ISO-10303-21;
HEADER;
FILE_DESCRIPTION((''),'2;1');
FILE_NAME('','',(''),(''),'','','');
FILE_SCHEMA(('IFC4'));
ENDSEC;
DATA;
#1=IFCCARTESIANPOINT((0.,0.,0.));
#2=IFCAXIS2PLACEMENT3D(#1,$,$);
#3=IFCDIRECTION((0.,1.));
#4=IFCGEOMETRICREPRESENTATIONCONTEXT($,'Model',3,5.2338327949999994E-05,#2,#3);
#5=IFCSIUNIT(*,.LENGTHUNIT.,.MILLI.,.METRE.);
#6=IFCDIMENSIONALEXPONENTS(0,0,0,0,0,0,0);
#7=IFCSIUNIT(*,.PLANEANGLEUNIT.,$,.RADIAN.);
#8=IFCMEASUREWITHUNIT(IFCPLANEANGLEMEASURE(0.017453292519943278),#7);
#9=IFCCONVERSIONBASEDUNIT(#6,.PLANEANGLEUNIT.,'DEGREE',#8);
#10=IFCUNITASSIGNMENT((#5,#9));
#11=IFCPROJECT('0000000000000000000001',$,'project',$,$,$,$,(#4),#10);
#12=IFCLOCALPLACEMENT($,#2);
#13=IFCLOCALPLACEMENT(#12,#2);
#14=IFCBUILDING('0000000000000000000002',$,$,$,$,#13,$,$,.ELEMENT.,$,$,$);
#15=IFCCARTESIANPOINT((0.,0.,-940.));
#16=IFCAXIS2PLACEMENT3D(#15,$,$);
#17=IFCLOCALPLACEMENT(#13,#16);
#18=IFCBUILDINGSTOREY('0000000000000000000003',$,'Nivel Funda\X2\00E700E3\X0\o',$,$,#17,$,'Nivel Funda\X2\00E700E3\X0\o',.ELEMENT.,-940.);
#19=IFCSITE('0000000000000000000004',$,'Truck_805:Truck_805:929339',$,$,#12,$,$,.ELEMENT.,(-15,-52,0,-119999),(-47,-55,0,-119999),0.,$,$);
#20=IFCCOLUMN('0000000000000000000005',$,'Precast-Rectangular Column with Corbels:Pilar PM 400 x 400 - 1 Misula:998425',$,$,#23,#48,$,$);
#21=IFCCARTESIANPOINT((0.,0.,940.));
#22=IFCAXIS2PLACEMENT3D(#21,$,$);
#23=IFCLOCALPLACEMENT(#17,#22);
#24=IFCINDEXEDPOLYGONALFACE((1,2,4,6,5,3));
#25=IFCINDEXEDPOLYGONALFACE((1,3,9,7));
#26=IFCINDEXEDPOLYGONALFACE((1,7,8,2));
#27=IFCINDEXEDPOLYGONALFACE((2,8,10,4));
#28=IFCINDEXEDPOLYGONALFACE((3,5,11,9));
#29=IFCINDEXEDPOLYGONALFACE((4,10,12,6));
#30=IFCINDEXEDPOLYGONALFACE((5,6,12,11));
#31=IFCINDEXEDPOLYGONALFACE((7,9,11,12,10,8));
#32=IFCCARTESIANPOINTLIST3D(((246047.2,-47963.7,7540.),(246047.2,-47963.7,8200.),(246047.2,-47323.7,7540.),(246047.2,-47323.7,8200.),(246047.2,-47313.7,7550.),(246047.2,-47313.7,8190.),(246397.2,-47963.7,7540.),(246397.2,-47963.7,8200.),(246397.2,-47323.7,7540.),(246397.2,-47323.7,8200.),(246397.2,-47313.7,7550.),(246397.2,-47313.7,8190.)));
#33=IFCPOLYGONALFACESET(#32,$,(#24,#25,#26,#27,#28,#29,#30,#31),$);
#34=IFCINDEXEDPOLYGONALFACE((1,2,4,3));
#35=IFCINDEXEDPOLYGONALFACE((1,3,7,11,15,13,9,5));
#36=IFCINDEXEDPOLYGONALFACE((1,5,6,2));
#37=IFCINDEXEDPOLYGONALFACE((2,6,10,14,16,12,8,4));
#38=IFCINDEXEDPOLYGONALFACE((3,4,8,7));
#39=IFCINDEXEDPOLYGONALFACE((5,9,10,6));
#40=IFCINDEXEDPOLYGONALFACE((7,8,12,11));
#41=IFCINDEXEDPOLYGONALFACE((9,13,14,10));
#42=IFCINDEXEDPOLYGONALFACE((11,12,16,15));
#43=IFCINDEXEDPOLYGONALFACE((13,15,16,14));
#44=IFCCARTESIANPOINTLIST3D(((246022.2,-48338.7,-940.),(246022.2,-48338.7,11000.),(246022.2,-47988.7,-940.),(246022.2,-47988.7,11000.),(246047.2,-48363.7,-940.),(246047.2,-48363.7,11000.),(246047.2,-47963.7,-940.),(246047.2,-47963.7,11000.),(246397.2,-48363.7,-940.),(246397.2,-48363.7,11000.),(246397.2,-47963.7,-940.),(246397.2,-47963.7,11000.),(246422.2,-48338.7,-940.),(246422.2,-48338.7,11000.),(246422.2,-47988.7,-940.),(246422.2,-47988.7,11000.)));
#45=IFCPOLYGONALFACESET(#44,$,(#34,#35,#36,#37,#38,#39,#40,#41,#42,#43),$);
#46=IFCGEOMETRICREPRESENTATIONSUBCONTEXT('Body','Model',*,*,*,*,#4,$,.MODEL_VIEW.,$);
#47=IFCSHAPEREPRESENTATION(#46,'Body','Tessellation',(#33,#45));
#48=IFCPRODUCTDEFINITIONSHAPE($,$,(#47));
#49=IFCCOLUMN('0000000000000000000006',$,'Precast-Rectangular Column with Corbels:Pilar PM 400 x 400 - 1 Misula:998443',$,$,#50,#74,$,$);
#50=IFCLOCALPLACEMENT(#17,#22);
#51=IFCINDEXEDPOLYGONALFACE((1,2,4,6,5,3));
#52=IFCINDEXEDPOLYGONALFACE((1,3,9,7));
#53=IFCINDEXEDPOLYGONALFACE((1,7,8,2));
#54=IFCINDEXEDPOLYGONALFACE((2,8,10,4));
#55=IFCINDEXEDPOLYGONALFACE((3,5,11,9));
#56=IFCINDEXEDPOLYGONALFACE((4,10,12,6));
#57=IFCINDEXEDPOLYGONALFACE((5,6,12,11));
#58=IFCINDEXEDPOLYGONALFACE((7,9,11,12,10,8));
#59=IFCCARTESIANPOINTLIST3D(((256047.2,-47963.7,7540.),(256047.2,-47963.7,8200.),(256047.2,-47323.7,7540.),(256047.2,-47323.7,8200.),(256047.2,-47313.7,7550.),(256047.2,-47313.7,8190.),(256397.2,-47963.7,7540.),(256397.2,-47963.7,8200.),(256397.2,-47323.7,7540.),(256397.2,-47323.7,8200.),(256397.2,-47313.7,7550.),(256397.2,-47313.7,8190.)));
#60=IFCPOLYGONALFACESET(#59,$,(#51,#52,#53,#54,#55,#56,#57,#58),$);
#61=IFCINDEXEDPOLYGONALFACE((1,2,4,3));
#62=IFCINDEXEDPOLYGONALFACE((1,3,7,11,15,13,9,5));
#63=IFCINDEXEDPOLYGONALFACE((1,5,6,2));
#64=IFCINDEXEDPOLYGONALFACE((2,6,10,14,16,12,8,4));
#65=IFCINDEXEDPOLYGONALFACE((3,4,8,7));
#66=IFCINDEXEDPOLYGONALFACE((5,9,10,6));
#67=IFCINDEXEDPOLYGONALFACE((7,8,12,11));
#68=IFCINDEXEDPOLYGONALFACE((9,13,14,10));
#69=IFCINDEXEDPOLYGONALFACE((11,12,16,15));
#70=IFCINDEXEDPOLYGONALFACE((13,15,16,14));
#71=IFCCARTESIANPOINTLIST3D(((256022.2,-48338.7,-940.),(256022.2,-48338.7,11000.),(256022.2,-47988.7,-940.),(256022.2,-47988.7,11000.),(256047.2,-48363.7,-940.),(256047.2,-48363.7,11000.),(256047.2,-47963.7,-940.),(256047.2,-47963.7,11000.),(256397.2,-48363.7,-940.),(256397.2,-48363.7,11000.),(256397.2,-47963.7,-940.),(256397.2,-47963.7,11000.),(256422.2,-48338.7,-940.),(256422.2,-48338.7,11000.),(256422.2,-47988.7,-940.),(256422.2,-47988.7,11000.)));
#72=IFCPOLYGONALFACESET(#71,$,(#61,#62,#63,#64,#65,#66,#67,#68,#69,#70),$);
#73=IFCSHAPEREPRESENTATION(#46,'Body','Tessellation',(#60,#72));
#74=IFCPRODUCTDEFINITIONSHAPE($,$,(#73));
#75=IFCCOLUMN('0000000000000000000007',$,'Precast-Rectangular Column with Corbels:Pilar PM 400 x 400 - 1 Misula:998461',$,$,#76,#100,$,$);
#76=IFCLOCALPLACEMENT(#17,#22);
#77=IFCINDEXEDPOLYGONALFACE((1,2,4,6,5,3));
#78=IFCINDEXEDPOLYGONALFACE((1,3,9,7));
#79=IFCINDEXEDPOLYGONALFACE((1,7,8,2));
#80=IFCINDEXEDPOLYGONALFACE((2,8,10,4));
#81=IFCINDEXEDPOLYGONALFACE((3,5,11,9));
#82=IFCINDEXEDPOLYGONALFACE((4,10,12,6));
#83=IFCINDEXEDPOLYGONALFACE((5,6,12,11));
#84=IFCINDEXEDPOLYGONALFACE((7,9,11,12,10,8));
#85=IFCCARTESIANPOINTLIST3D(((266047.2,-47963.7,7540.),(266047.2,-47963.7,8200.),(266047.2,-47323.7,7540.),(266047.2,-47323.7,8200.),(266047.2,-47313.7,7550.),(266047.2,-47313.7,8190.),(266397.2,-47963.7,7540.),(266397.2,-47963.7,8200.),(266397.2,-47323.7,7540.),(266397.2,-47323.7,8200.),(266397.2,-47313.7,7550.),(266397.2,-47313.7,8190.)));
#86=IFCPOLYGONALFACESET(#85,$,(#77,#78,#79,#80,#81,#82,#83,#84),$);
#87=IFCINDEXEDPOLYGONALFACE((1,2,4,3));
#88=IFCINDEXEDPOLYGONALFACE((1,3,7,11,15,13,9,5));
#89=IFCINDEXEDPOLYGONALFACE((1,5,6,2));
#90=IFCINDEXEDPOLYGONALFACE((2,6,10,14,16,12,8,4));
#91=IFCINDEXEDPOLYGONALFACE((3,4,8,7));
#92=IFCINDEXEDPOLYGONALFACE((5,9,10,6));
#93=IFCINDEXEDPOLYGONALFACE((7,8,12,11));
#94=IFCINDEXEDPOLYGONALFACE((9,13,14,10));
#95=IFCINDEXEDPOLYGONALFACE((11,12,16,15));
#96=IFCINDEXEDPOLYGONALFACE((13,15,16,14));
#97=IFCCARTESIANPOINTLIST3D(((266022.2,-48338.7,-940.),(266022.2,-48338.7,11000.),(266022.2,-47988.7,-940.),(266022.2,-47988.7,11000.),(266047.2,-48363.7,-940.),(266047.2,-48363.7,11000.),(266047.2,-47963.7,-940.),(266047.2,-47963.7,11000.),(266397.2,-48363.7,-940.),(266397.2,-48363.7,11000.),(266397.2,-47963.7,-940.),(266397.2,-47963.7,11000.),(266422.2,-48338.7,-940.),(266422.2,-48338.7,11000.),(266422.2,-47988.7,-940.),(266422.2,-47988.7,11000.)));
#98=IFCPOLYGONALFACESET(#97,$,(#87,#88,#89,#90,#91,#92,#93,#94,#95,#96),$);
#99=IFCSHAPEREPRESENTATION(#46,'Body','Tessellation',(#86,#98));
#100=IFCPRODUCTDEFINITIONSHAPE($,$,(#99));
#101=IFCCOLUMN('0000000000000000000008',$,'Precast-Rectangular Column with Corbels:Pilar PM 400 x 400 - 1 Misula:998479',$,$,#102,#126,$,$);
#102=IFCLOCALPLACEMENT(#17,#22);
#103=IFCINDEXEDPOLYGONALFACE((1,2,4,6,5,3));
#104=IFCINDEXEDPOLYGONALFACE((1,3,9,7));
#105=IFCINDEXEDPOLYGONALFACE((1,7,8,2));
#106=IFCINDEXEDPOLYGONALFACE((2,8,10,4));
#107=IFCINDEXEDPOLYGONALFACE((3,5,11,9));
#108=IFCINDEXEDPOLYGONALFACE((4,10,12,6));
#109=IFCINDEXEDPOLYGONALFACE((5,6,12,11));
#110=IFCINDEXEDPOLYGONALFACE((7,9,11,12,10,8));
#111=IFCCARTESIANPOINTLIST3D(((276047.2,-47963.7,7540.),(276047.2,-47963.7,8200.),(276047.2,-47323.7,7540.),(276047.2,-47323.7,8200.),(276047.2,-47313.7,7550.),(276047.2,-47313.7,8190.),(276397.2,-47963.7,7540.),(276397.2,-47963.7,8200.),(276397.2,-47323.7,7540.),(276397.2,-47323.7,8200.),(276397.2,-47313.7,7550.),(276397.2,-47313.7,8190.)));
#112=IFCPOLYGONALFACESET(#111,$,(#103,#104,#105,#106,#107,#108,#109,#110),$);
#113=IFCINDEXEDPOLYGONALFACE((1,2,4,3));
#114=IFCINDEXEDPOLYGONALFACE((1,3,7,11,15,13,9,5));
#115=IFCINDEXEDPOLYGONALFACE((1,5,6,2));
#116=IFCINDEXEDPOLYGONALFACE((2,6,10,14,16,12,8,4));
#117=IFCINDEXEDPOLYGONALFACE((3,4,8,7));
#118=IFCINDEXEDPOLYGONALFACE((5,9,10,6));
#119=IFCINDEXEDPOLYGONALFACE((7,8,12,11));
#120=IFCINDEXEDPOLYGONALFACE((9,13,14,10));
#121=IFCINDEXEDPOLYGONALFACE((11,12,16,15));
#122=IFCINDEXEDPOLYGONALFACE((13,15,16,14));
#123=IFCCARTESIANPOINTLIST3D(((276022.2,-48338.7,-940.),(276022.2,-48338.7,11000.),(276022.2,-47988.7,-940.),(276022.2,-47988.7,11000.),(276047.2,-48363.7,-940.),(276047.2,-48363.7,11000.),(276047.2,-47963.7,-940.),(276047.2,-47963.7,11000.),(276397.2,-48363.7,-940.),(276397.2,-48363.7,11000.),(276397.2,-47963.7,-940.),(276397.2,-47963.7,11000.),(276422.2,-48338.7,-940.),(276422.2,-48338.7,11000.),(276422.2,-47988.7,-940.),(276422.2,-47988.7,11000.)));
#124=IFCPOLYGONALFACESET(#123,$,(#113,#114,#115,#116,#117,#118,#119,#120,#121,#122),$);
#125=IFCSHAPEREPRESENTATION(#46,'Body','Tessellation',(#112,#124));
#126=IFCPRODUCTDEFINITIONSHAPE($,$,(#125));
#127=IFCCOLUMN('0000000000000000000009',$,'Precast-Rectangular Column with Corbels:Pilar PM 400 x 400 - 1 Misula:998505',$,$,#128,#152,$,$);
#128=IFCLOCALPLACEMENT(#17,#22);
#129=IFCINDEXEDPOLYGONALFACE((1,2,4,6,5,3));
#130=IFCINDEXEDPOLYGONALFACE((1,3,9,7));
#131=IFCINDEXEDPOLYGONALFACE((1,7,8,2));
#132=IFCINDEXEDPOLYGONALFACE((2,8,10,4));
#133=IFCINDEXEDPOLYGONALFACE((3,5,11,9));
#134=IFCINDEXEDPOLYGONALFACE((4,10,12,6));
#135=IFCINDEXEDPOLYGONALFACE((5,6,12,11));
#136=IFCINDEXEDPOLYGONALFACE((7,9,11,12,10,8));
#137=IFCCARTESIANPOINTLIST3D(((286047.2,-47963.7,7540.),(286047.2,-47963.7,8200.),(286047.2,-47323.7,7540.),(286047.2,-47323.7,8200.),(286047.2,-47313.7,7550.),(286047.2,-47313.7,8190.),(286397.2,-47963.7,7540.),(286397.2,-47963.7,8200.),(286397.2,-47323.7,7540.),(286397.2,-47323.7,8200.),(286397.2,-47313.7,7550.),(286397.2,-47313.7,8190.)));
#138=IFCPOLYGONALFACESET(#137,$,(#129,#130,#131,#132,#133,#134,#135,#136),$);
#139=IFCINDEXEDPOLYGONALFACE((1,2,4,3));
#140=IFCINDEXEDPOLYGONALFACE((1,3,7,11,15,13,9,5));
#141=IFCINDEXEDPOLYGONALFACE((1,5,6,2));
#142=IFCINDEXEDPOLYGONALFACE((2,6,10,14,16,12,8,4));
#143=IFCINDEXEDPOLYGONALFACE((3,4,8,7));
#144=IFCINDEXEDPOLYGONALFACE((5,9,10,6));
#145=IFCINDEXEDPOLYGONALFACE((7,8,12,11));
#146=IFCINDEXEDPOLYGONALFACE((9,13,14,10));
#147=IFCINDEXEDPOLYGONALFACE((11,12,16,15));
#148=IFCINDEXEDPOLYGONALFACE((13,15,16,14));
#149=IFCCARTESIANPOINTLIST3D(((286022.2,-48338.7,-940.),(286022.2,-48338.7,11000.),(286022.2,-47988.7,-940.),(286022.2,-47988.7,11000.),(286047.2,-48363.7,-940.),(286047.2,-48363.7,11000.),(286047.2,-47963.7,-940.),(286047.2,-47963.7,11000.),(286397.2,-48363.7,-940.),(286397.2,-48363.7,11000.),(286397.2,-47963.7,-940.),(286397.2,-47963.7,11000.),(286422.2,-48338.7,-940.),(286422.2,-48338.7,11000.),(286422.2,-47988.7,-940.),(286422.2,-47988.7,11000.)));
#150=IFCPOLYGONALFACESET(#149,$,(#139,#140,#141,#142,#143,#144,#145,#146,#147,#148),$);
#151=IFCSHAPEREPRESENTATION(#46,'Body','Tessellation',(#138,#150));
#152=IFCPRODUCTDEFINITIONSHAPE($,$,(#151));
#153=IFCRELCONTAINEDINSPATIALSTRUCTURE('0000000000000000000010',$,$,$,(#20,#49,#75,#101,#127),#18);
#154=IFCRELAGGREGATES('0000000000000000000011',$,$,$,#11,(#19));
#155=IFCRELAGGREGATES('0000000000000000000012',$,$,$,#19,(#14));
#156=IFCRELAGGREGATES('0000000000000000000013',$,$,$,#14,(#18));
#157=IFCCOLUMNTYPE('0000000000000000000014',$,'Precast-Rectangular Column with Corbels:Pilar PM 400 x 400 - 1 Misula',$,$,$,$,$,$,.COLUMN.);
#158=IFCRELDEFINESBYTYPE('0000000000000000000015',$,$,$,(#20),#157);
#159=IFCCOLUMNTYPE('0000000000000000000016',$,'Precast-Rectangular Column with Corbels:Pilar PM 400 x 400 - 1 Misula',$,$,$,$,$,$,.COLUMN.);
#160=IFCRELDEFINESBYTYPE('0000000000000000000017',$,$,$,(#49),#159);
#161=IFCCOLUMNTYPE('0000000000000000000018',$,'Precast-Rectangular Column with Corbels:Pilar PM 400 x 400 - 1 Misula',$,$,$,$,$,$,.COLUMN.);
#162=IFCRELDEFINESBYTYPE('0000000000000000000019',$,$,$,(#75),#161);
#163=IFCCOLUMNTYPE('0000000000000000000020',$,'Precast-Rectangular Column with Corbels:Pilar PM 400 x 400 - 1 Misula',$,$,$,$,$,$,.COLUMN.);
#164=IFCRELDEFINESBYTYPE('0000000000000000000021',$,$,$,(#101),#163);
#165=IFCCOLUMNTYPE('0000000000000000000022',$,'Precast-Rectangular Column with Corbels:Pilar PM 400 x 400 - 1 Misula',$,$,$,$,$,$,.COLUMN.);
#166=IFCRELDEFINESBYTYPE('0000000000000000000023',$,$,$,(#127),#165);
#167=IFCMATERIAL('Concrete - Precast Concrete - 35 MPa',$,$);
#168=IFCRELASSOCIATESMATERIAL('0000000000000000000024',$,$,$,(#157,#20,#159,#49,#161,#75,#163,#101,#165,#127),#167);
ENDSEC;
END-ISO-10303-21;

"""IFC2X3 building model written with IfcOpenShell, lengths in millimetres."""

from ifc_helpers import new_model, entity, si_unit, converted_unit, direction, frame, origin, place, context, subcontext, project, spatial, polyline, outline, extrude, source, transform, mapped, material, type_object, type_shapes, element, save


model = new_model("IFC2X3")

# Units and contexts
model_context = context("Model", 3, precision=5.2338327949999994e-05, world=origin(), true_north=direction((0.0, 1.0)))
body_context = subcontext(model_context, "Body", "Model", "MODEL_VIEW")
ifc_project = project(units=[si_unit("LENGTHUNIT", "METRE", prefix="MILLI"), converted_unit("PLANEANGLEUNIT", "DEGREE", entity("IfcPlaneAngleMeasure", 0.017453292519943278), si_unit("PLANEANGLEUNIT", "RADIAN"), dimensions=[0, 0, 0, 0, 0, 0, 0])], contexts=[model_context])

# Site, building, storey
site_placement = place(None, origin())
site = spatial("IfcSite", under=ifc_project, at=site_placement, Name="Truck_805:Truck_805:929339", CompositionType="ELEMENT", RefLatitude=(-15, -52, 0, -119999), RefLongitude=(-47, -55, 0, -119999), RefElevation=0.0)
building_placement = place(site_placement, origin())
building = spatial("IfcBuilding", under=site, at=building_placement, CompositionType="ELEMENT")
storey_placement = place(building_placement, frame((0.0, 0.0, -940.0)))
storey = spatial("IfcBuildingStorey", under=building, at=storey_placement, Name="Nivel Fundação", LongName="Nivel Fundação", CompositionType="ELEMENT", Elevation=-940.0)

# Columns
ifc_material = material(Name="Concrete - Precast Concrete - 35 MPa")
column_type_1 = type_object("IfcColumnType", Name="Precast-Rectangular Column with Corbels:Pilar PM 400 x 400 - 1 Misula", PredefinedType="COLUMN", material=ifc_material)
shared_shape_1 = source(origin(), body_context, "Body", "SweptSolid", [
    extrude(outline(polyline([(-210.0, -330.0), (430.0, -330.0), (430.0, 330.0), (-210.0, 330.0), (-220.0, 320.0), (-220.0, -320.0), (-210.0, -330.0)])), frame((246047.2, -47533.7, 7870.0), z_axis=(1.0, 0.0, 0.0), x_axis=(0.0, -1.0, 0.0)), (0.0, 0.0, 1.0), 350.0),
    extrude(outline(polyline([(-175.0, -200.0), (175.0, -200.0), (200.0, -175.0), (200.0, 175.0), (175.0, 200.0), (-175.0, 200.0), (-200.0, 175.0), (-200.0, -175.0), (-175.0, -200.0)])), frame((246222.2, -48163.7, -940.0)), (0.0, 0.0, 1.0), 11940.0),
])
type_shapes(column_type_1, [shared_shape_1])
column_1_placement = place(storey_placement, frame((0.0, 0.0, 940.0)))
element("IfcColumn", 1, at=column_1_placement, inside=storey, type_object=column_type_1, material=ifc_material, Name="Precast-Rectangular Column with Corbels:Pilar PM 400 x 400 - 1 Misula:998425", context=body_context, shape_type="MappedRepresentation", body=[
    mapped(shared_shape_1, transform((0.0, 0.0, 0.0), scale=1.0)),
])
column_type_2 = type_object("IfcColumnType", Name="Precast-Rectangular Column with Corbels:Pilar PM 400 x 400 - 1 Misula", PredefinedType="COLUMN", material=ifc_material)
shared_shape_2 = source(origin(), body_context, "Body", "SweptSolid", [
    extrude(outline(polyline([(-210.0, -330.0), (430.0, -330.0), (430.0, 330.0), (-210.0, 330.0), (-220.0, 320.0), (-220.0, -320.0), (-210.0, -330.0)])), frame((256047.2, -47533.7, 7870.0), z_axis=(1.0, 0.0, 0.0), x_axis=(0.0, -1.0, 0.0)), (0.0, 0.0, 1.0), 350.0),
    extrude(outline(polyline([(-175.0, -200.0), (175.0, -200.0), (200.0, -175.0), (200.0, 175.0), (175.0, 200.0), (-175.0, 200.0), (-200.0, 175.0), (-200.0, -175.0), (-175.0, -200.0)])), frame((256222.2, -48163.7, -940.0)), (0.0, 0.0, 1.0), 11940.0),
])
type_shapes(column_type_2, [shared_shape_2])
column_2_placement = place(storey_placement, frame((0.0, 0.0, 940.0)))
element("IfcColumn", 2, at=column_2_placement, inside=storey, type_object=column_type_2, material=ifc_material, Name="Precast-Rectangular Column with Corbels:Pilar PM 400 x 400 - 1 Misula:998443", context=body_context, shape_type="MappedRepresentation", body=[
    mapped(shared_shape_2, transform((0.0, 0.0, 0.0), scale=1.0)),
])
column_type_3 = type_object("IfcColumnType", Name="Precast-Rectangular Column with Corbels:Pilar PM 400 x 400 - 1 Misula", PredefinedType="COLUMN", material=ifc_material)
shared_shape_3 = source(origin(), body_context, "Body", "SweptSolid", [
    extrude(outline(polyline([(-210.0, -330.0), (430.0, -330.0), (430.0, 330.0), (-210.0, 330.0), (-220.0, 320.0), (-220.0, -320.0), (-210.0, -330.0)])), frame((266047.2, -47533.7, 7870.0), z_axis=(1.0, 0.0, 0.0), x_axis=(0.0, -1.0, 0.0)), (0.0, 0.0, 1.0), 350.0),
    extrude(outline(polyline([(-175.0, -200.0), (175.0, -200.0), (200.0, -175.0), (200.0, 175.0), (175.0, 200.0), (-175.0, 200.0), (-200.0, 175.0), (-200.0, -175.0), (-175.0, -200.0)])), frame((266222.2, -48163.7, -940.0)), (0.0, 0.0, 1.0), 11940.0),
])
type_shapes(column_type_3, [shared_shape_3])
column_3_placement = place(storey_placement, frame((0.0, 0.0, 940.0)))
element("IfcColumn", 3, at=column_3_placement, inside=storey, type_object=column_type_3, material=ifc_material, Name="Precast-Rectangular Column with Corbels:Pilar PM 400 x 400 - 1 Misula:998461", context=body_context, shape_type="MappedRepresentation", body=[
    mapped(shared_shape_3, transform((0.0, 0.0, 0.0), scale=1.0)),
])
column_type_4 = type_object("IfcColumnType", Name="Precast-Rectangular Column with Corbels:Pilar PM 400 x 400 - 1 Misula", PredefinedType="COLUMN", material=ifc_material)
shared_shape_4 = source(origin(), body_context, "Body", "SweptSolid", [
    extrude(outline(polyline([(-210.0, -330.0), (430.0, -330.0), (430.0, 330.0), (-210.0, 330.0), (-220.0, 320.0), (-220.0, -320.0), (-210.0, -330.0)])), frame((276047.2, -47533.7, 7870.0), z_axis=(1.0, 0.0, 0.0), x_axis=(0.0, -1.0, 0.0)), (0.0, 0.0, 1.0), 350.0),
    extrude(outline(polyline([(-175.0, -200.0), (175.0, -200.0), (200.0, -175.0), (200.0, 175.0), (175.0, 200.0), (-175.0, 200.0), (-200.0, 175.0), (-200.0, -175.0), (-175.0, -200.0)])), frame((276222.2, -48163.7, -940.0)), (0.0, 0.0, 1.0), 11940.0),
])
type_shapes(column_type_4, [shared_shape_4])
column_4_placement = place(storey_placement, frame((0.0, 0.0, 940.0)))
element("IfcColumn", 4, at=column_4_placement, inside=storey, type_object=column_type_4, material=ifc_material, Name="Precast-Rectangular Column with Corbels:Pilar PM 400 x 400 - 1 Misula:998479", context=body_context, shape_type="MappedRepresentation", body=[
    mapped(shared_shape_4, transform((0.0, 0.0, 0.0), scale=1.0)),
])
column_type_5 = type_object("IfcColumnType", Name="Precast-Rectangular Column with Corbels:Pilar PM 400 x 400 - 1 Misula", PredefinedType="COLUMN", material=ifc_material)
shared_shape_5 = source(origin(), body_context, "Body", "SweptSolid", [
    extrude(outline(polyline([(-210.0, -330.0), (430.0, -330.0), (430.0, 330.0), (-210.0, 330.0), (-220.0, 320.0), (-220.0, -320.0), (-210.0, -330.0)])), frame((286047.2, -47533.7, 7870.0), z_axis=(1.0, 0.0, 0.0), x_axis=(0.0, -1.0, 0.0)), (0.0, 0.0, 1.0), 350.0),
    extrude(outline(polyline([(-175.0, -200.0), (175.0, -200.0), (200.0, -175.0), (200.0, 175.0), (175.0, 200.0), (-175.0, 200.0), (-200.0, 175.0), (-200.0, -175.0), (-175.0, -200.0)])), frame((286222.2, -48163.7, -940.0)), (0.0, 0.0, 1.0), 11940.0),
])
type_shapes(column_type_5, [shared_shape_5])
column_5_placement = place(storey_placement, frame((0.0, 0.0, 940.0)))
element("IfcColumn", 5, at=column_5_placement, inside=storey, type_object=column_type_5, material=ifc_material, Name="Precast-Rectangular Column with Corbels:Pilar PM 400 x 400 - 1 Misula:998505", context=body_context, shape_type="MappedRepresentation", body=[
    mapped(shared_shape_5, transform((0.0, 0.0, 0.0), scale=1.0)),
])

save(model, "model.ifc")
